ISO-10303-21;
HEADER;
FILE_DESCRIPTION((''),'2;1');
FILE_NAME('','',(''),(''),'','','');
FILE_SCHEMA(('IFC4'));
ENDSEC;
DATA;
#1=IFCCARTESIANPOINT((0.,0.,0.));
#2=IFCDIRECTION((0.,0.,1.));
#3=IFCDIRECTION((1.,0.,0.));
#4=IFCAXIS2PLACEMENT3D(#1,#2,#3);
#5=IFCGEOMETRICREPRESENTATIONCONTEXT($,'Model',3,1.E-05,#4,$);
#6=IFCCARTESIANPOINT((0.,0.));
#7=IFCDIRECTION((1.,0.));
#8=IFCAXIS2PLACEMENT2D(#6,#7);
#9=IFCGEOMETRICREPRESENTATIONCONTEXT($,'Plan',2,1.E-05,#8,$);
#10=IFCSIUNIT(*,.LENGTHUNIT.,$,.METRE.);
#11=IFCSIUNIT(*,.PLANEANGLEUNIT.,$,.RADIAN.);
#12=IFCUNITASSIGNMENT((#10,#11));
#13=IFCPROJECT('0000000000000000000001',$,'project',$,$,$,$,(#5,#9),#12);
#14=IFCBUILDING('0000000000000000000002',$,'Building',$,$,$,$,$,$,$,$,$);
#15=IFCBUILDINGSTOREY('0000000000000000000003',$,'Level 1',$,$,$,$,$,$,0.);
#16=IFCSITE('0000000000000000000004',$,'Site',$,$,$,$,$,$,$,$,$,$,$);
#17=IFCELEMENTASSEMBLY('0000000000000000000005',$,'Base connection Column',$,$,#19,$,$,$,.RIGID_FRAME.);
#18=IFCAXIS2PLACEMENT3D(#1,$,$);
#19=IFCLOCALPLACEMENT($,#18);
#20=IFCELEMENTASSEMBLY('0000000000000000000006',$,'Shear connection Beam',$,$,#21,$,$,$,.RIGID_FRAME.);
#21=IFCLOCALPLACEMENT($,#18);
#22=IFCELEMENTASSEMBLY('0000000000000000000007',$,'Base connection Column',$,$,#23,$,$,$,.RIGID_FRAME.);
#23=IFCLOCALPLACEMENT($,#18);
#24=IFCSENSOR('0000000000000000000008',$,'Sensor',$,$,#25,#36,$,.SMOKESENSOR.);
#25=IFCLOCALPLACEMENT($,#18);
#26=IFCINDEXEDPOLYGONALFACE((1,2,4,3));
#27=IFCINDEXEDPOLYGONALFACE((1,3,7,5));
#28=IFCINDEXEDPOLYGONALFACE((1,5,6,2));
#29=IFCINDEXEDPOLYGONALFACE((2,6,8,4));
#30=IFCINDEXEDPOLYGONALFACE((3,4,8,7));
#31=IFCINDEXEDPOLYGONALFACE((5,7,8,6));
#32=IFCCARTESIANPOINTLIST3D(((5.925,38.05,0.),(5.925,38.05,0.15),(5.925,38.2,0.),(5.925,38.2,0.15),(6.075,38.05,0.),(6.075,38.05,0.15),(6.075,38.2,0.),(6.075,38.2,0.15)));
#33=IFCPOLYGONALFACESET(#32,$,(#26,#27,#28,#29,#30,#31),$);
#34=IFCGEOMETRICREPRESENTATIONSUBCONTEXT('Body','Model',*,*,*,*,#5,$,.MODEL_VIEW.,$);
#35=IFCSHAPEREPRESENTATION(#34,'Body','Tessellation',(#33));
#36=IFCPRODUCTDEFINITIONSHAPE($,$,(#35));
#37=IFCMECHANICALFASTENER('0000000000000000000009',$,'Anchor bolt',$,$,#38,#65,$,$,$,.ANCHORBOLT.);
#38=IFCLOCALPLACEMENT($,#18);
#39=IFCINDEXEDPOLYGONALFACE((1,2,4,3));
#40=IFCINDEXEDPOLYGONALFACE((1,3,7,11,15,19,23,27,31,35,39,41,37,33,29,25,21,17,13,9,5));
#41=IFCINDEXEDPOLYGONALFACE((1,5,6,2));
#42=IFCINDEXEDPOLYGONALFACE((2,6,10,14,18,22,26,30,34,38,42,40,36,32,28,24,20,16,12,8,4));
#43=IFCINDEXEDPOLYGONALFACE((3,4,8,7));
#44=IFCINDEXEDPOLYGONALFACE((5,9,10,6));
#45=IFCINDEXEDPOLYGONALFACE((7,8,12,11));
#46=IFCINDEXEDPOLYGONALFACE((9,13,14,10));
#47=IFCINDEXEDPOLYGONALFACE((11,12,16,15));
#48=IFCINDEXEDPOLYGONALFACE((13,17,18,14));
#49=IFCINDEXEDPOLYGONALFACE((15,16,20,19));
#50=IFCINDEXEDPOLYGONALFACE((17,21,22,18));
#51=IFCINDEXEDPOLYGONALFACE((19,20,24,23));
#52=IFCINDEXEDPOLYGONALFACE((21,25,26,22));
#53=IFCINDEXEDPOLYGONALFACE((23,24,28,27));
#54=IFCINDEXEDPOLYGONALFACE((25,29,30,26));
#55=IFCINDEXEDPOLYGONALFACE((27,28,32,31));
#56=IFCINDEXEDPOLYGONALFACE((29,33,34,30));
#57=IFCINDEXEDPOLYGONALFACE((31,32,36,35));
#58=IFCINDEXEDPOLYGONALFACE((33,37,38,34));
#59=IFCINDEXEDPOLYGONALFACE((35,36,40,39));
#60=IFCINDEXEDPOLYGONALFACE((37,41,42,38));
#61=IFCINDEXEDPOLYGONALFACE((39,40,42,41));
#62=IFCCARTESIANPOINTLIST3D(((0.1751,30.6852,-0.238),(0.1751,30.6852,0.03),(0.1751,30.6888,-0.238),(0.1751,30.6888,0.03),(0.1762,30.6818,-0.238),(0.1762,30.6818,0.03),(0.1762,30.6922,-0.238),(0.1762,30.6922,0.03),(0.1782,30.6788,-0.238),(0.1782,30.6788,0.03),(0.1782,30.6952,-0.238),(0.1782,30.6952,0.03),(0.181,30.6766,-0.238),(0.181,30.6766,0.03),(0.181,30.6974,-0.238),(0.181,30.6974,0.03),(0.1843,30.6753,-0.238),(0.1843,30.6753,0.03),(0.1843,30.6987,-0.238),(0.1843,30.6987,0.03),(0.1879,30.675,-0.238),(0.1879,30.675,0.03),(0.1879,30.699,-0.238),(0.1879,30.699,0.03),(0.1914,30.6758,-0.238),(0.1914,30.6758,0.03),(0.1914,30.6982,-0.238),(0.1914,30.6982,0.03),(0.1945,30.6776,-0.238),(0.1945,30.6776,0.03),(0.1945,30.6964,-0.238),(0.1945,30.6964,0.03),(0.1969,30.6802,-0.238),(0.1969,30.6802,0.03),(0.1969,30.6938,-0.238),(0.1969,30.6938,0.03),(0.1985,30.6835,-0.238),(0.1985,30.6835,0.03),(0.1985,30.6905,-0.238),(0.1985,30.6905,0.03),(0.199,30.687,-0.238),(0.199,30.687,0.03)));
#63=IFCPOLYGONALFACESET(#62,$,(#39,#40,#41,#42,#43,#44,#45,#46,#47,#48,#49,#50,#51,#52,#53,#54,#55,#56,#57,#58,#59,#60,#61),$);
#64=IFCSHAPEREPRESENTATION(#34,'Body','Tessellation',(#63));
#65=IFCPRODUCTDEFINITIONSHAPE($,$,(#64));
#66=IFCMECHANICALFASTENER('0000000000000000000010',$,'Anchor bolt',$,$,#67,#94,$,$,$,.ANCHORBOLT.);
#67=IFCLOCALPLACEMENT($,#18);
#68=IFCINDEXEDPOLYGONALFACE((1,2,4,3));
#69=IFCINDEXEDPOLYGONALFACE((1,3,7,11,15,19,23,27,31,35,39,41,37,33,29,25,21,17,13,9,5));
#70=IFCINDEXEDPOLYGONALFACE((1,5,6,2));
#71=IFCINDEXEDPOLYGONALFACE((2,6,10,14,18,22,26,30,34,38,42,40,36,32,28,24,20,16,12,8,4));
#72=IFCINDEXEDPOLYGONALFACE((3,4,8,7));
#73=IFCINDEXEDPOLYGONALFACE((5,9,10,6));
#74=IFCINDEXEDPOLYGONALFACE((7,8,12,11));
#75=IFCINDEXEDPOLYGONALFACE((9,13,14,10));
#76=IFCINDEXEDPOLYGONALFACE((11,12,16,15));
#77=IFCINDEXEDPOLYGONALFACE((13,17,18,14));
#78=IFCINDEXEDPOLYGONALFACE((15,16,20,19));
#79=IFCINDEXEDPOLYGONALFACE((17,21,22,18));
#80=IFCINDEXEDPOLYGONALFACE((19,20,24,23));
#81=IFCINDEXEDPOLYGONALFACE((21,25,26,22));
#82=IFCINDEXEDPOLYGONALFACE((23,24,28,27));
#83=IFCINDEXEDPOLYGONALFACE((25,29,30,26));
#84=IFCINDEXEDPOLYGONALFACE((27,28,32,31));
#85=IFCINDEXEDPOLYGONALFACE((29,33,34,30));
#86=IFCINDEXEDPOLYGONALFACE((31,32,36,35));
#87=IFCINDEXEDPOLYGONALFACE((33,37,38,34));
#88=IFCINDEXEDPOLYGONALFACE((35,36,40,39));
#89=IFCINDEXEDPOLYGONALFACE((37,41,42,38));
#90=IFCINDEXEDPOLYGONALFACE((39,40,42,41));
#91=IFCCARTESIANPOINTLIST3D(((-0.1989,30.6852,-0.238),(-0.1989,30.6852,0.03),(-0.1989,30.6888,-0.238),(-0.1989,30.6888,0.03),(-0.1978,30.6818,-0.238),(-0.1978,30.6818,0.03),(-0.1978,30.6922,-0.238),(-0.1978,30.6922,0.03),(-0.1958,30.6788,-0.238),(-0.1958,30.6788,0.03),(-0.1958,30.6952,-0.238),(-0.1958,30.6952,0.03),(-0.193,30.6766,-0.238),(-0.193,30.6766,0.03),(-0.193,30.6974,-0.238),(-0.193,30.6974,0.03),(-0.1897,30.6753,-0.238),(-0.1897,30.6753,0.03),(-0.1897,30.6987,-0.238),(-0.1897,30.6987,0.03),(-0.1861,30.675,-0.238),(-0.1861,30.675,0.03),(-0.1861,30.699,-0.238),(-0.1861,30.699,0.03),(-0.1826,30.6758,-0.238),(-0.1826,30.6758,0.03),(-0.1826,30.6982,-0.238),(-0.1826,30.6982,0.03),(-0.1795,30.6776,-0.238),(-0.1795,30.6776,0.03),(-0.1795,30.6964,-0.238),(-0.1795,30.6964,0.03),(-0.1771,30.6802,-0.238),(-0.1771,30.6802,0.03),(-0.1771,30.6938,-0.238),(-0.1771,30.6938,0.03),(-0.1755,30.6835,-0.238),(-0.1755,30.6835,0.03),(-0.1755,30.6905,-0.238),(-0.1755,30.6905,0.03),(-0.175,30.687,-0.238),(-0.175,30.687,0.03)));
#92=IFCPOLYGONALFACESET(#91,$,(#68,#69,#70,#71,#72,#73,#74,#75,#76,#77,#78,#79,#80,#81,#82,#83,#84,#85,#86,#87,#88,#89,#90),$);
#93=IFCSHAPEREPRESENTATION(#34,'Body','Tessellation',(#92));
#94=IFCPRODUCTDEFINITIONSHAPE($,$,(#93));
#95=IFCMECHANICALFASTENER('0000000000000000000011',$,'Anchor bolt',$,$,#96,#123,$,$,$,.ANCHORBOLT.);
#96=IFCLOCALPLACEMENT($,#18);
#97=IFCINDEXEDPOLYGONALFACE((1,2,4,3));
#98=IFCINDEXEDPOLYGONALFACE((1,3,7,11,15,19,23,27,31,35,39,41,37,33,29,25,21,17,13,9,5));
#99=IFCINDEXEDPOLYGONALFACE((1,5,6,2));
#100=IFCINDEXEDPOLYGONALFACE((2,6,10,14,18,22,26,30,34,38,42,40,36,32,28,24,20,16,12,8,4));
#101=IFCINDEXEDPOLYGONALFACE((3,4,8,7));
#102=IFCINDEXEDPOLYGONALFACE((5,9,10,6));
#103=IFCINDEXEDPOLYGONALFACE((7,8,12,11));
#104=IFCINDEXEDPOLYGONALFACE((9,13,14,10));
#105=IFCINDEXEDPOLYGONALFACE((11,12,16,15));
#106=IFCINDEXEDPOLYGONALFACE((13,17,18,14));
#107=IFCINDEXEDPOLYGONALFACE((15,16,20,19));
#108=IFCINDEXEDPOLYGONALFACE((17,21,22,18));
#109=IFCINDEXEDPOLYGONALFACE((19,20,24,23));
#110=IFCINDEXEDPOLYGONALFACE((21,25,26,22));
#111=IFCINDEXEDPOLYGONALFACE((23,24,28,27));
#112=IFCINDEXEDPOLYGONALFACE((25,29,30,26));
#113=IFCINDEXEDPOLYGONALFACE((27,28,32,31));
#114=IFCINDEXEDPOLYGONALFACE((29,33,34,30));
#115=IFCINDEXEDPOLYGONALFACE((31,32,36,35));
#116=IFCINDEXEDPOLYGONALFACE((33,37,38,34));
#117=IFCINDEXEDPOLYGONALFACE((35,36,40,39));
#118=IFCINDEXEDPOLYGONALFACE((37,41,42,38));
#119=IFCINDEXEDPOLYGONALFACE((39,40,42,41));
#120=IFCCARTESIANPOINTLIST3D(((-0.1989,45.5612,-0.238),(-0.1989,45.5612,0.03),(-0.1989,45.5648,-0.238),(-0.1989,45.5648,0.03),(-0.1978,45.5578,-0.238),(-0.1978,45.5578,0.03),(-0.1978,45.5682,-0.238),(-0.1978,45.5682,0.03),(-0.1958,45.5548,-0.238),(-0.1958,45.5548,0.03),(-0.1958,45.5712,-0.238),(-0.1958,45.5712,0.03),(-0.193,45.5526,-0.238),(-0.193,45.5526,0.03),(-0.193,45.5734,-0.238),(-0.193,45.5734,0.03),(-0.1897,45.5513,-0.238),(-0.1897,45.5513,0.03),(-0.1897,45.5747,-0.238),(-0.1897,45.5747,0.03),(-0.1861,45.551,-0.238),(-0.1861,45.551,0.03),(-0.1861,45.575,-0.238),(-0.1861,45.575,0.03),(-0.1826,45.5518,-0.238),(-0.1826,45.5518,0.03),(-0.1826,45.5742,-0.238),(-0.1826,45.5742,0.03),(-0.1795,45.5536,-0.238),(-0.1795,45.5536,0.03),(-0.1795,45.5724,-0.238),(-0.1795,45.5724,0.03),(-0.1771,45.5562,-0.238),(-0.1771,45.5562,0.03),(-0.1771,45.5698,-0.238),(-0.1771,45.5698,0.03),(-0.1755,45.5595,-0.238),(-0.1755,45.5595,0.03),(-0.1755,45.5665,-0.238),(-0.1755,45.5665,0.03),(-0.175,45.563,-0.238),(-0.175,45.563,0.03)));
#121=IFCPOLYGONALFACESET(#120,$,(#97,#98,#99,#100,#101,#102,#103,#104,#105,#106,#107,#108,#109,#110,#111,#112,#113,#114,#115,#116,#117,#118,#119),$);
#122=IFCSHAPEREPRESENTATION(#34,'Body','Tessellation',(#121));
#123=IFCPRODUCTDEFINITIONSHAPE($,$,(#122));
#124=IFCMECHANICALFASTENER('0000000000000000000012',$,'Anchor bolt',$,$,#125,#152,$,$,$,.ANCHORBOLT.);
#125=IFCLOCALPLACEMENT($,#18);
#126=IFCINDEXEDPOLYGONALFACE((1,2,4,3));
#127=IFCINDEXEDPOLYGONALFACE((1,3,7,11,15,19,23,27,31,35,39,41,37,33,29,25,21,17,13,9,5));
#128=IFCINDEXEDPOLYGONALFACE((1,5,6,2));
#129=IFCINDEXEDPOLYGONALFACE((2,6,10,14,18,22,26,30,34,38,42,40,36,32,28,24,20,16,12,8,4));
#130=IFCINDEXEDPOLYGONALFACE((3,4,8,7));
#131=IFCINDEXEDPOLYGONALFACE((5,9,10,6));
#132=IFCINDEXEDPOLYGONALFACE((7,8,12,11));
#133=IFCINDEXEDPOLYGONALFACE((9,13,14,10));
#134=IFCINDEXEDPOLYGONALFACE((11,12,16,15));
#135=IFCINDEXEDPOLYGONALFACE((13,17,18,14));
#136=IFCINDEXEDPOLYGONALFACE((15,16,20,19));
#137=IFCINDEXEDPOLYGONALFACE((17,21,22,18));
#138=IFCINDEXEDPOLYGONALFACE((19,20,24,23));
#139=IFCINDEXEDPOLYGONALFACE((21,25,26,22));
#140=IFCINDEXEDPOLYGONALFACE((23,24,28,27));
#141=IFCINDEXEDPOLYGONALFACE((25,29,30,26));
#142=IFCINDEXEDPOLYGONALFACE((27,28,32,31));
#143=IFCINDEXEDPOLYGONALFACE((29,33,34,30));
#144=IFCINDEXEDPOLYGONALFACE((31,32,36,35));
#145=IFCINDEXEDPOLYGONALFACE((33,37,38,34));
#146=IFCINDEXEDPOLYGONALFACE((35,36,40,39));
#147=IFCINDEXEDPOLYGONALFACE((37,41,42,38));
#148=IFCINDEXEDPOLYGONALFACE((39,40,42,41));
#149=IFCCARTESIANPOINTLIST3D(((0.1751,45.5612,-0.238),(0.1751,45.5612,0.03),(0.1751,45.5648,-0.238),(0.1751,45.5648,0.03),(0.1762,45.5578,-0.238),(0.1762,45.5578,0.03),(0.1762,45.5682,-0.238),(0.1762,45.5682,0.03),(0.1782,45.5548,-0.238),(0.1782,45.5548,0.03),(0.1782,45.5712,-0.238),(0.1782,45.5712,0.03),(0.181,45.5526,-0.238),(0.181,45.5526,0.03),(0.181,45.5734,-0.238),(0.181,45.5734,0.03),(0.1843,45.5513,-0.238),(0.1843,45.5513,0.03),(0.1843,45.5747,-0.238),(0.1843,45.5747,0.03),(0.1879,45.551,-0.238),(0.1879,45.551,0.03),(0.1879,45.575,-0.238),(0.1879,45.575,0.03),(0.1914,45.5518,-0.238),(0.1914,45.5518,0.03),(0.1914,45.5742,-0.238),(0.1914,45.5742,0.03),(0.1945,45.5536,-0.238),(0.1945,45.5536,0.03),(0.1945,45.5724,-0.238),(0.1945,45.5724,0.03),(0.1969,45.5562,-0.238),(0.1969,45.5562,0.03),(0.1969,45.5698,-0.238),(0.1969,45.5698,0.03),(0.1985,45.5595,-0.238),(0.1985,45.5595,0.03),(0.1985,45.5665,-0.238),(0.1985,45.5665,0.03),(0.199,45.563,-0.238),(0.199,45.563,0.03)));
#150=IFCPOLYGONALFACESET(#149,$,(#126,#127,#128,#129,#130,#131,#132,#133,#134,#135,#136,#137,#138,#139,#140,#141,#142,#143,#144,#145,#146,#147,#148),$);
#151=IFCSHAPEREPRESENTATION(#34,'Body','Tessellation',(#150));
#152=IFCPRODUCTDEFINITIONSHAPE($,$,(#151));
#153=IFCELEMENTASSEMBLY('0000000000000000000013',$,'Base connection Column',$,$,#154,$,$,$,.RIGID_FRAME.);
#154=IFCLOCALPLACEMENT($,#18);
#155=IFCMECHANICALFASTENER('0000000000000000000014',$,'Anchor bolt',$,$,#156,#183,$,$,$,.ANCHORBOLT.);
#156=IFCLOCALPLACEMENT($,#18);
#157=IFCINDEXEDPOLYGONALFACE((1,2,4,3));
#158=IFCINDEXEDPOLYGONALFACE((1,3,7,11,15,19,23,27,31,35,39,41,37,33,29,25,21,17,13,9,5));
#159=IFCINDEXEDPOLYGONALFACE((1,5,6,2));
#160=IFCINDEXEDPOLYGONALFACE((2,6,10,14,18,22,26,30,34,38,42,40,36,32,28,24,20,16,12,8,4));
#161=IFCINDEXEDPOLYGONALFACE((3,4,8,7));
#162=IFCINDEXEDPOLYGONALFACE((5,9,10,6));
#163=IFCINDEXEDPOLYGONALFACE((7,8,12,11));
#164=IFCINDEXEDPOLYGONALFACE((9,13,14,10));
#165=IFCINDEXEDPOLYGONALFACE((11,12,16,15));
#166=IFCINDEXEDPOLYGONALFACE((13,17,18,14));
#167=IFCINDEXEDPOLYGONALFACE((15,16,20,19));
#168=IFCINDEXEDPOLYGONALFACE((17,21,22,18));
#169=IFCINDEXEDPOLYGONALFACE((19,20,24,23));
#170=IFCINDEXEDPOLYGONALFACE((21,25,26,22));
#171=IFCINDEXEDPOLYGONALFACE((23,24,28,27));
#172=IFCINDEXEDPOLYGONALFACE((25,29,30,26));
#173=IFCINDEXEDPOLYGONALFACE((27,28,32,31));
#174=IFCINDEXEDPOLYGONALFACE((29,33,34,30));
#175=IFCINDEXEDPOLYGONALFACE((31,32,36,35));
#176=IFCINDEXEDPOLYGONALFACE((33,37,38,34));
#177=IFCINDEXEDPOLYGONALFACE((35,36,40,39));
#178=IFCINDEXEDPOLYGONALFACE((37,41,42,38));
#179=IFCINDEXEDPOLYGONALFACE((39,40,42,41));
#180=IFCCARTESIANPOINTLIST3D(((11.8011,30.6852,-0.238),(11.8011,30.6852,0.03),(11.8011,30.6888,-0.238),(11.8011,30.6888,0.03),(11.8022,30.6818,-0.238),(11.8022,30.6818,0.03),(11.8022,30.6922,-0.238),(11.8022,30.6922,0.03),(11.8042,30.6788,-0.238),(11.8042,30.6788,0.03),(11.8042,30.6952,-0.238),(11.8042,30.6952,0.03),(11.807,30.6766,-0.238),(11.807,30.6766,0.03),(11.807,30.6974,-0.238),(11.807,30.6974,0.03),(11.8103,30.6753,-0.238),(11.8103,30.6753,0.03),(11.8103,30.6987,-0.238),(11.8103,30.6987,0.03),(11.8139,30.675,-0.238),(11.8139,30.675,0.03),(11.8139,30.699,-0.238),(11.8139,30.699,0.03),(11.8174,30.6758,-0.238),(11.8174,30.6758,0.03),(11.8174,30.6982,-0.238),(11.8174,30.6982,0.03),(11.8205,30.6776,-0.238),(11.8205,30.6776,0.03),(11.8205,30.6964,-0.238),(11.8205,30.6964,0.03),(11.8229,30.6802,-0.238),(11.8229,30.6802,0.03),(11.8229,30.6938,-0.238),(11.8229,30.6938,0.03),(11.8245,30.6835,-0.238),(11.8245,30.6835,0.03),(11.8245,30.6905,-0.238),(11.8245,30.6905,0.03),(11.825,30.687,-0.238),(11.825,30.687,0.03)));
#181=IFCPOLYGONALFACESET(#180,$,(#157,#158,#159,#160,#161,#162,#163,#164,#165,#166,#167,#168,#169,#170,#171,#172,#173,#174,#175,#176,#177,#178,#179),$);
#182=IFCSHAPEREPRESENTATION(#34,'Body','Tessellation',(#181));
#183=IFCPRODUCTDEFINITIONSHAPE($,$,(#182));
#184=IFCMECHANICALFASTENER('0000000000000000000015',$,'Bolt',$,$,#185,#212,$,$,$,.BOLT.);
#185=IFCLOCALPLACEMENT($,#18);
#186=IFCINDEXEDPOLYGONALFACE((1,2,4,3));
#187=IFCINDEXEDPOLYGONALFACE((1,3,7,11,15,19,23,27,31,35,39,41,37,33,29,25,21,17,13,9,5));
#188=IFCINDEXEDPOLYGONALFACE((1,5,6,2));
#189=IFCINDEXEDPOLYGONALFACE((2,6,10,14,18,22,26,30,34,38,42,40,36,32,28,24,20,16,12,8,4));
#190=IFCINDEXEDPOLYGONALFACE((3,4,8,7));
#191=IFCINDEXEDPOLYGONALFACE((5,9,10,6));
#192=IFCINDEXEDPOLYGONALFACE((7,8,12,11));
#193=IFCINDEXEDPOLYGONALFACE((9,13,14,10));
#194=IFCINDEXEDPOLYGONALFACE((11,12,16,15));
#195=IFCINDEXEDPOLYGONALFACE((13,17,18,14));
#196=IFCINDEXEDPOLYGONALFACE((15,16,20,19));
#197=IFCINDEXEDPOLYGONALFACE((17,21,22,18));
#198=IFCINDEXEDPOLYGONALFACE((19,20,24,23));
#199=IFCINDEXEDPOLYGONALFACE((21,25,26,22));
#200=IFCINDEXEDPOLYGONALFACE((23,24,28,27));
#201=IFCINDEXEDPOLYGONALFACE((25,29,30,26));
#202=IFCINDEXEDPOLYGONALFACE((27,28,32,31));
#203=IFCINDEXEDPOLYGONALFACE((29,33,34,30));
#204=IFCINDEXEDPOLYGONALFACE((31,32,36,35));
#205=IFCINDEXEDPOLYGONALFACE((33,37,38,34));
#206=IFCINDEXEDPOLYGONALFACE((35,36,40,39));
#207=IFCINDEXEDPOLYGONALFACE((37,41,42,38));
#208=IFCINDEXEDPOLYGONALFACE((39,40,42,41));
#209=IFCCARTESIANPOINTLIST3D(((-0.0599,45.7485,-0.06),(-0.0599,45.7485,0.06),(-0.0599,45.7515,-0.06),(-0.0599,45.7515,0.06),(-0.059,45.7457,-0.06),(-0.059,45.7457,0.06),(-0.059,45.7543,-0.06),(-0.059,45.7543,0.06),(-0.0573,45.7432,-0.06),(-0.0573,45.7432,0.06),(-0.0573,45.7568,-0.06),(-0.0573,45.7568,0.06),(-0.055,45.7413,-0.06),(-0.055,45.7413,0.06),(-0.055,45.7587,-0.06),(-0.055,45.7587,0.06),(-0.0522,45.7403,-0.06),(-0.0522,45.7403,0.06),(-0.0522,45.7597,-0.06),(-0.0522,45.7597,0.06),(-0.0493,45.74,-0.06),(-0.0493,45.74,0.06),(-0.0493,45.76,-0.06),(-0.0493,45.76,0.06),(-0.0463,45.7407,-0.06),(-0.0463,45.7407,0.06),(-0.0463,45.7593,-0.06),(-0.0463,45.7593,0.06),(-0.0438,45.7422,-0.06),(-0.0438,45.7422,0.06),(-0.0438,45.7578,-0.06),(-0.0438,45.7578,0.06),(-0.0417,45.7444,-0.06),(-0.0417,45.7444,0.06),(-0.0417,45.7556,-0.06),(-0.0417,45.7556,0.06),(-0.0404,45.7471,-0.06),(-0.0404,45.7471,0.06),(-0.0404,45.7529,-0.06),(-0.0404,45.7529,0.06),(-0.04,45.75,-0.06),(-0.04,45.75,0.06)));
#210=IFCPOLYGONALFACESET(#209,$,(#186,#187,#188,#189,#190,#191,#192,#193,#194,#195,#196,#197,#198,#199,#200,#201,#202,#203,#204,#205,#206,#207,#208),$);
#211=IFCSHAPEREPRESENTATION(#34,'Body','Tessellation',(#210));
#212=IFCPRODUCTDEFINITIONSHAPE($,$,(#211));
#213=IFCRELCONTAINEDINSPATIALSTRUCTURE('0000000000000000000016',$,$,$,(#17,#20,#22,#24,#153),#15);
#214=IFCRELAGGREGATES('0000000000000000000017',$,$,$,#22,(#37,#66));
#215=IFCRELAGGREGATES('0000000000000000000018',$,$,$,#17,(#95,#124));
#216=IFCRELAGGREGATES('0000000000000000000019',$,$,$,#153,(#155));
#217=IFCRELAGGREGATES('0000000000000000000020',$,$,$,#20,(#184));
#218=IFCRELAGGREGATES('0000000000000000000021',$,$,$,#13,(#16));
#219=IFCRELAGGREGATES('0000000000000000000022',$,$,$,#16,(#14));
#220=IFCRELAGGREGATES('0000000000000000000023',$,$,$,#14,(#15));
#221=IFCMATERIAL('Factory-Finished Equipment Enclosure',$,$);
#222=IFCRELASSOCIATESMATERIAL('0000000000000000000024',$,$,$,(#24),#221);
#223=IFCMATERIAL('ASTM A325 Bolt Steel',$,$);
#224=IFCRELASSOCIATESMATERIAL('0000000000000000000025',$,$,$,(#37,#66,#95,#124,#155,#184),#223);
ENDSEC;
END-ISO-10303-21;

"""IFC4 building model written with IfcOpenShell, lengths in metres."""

from ifc_helpers import new_model, si_unit, frame, origin_with_axes, origin_2d, origin_2d_with_axis, place, context, subcontext, project, spatial, rectangle, circle, extrude, material, element, aggregate, save


model = new_model("IFC4")

# Units and contexts
model_context = context("Model", 3, precision=1e-05, world=origin_with_axes())
plan_context = context("Plan", 2, precision=1e-05, world=origin_2d_with_axis())
body_context = subcontext(model_context, "Body", "Model", "MODEL_VIEW")
ifc_project = project(units=[si_unit("LENGTHUNIT", "METRE"), si_unit("PLANEANGLEUNIT", "RADIAN")], contexts=[model_context, plan_context])

# Site, building, storey
site = spatial("IfcSite", under=ifc_project, Name="Site")
building = spatial("IfcBuilding", under=site, Name="Building")
storey = spatial("IfcBuildingStorey", under=building, Name="Level 1", Elevation=0.0)

# Element assembly
assembly_1 = element("IfcElementAssembly", 1, inside=storey, Name="Base connection Column", PredefinedType="RIGID_FRAME")

# Element assembly
assembly_2 = element("IfcElementAssembly", 2, inside=storey, Name="Shear connection Beam", PredefinedType="RIGID_FRAME")

# Element assembly
assembly_3 = element("IfcElementAssembly", 3, inside=storey, Name="Base connection Column", PredefinedType="RIGID_FRAME")

# Shared definitions
ifc_material_1 = material(Name="Factory-Finished Equipment Enclosure")

# Sensor
sensor_placement = place(None, frame((6.0, 38.125, 0.0), z_axis=(0.0, 0.0, 1.0), x_axis=(1.0, 0.0, 0.0)))
element("IfcSensor", 4, at=sensor_placement, inside=storey, material=ifc_material_1, Name="Sensor", PredefinedType="SMOKESENSOR", context=body_context, shape_type="SweptSolid", body=[
    extrude(rectangle(XDim=0.15, YDim=0.15, at=origin_2d_with_axis()), origin_with_axes(), (0.0, 0.0, 1.0), 0.15),
])

# Mechanical fasteners
ifc_material_2 = material(Name="ASTM A325 Bolt Steel")
mechanical_fastener_1_placement = place(None, frame((0.187, 30.687, -0.238), z_axis=(0.0, 0.0, 1.0), x_axis=(1.0, 0.0, 0.0)))
mechanical_fastener_1 = element("IfcMechanicalFastener", 5, at=mechanical_fastener_1_placement, material=ifc_material_2, Name="Anchor bolt", PredefinedType="ANCHORBOLT", context=body_context, shape_type="SweptSolid", body=[
    extrude(circle(Radius=0.012, at=origin_2d()), origin_with_axes(), (0.0, 0.0, 1.0), 0.268),
])
mechanical_fastener_2_placement = place(None, frame((-0.187, 30.687, -0.238), z_axis=(0.0, 0.0, 1.0), x_axis=(1.0, 0.0, 0.0)))
mechanical_fastener_2 = element("IfcMechanicalFastener", 6, at=mechanical_fastener_2_placement, material=ifc_material_2, Name="Anchor bolt", PredefinedType="ANCHORBOLT", context=body_context, shape_type="SweptSolid", body=[
    extrude(circle(Radius=0.012, at=origin_2d()), origin_with_axes(), (0.0, 0.0, 1.0), 0.268),
])
aggregate(assembly_3, [mechanical_fastener_1, mechanical_fastener_2])
mechanical_fastener_3_placement = place(None, frame((-0.187, 45.563, -0.238), z_axis=(0.0, 0.0, 1.0), x_axis=(1.0, 0.0, 0.0)))
mechanical_fastener_3 = element("IfcMechanicalFastener", 7, at=mechanical_fastener_3_placement, material=ifc_material_2, Name="Anchor bolt", PredefinedType="ANCHORBOLT", context=body_context, shape_type="SweptSolid", body=[
    extrude(circle(Radius=0.012, at=origin_2d()), origin_with_axes(), (0.0, 0.0, 1.0), 0.268),
])
mechanical_fastener_4_placement = place(None, frame((0.187, 45.563, -0.238), z_axis=(0.0, 0.0, 1.0), x_axis=(1.0, 0.0, 0.0)))
mechanical_fastener_4 = element("IfcMechanicalFastener", 8, at=mechanical_fastener_4_placement, material=ifc_material_2, Name="Anchor bolt", PredefinedType="ANCHORBOLT", context=body_context, shape_type="SweptSolid", body=[
    extrude(circle(Radius=0.012, at=origin_2d()), origin_with_axes(), (0.0, 0.0, 1.0), 0.268),
])
aggregate(assembly_1, [mechanical_fastener_3, mechanical_fastener_4])

# Element assembly, mechanical fastener
assembly_4 = element("IfcElementAssembly", 9, inside=storey, Name="Base connection Column", PredefinedType="RIGID_FRAME")
mechanical_fastener_5_placement = place(None, frame((11.813, 30.687, -0.238), z_axis=(0.0, 0.0, 1.0), x_axis=(1.0, 0.0, 0.0)))
mechanical_fastener_5 = element("IfcMechanicalFastener", 10, at=mechanical_fastener_5_placement, material=ifc_material_2, Name="Anchor bolt", PredefinedType="ANCHORBOLT", context=body_context, shape_type="SweptSolid", body=[
    extrude(circle(Radius=0.012, at=origin_2d()), origin_with_axes(), (0.0, 0.0, 1.0), 0.268),
])
aggregate(assembly_4, [mechanical_fastener_5])

# Mechanical fastener
mechanical_fastener_6_placement = place(None, frame((-0.05, 45.75, -0.06), z_axis=(0.0, 0.0, 1.0), x_axis=(1.0, 0.0, 0.0)))
mechanical_fastener_6 = element("IfcMechanicalFastener", 11, at=mechanical_fastener_6_placement, material=ifc_material_2, Name="Bolt", PredefinedType="BOLT", context=body_context, shape_type="SweptSolid", body=[
    extrude(circle(Radius=0.01, at=origin_2d()), origin_with_axes(), (0.0, 0.0, 1.0), 0.12),
])
aggregate(assembly_2, [mechanical_fastener_6])

save(model, "model.ifc")
